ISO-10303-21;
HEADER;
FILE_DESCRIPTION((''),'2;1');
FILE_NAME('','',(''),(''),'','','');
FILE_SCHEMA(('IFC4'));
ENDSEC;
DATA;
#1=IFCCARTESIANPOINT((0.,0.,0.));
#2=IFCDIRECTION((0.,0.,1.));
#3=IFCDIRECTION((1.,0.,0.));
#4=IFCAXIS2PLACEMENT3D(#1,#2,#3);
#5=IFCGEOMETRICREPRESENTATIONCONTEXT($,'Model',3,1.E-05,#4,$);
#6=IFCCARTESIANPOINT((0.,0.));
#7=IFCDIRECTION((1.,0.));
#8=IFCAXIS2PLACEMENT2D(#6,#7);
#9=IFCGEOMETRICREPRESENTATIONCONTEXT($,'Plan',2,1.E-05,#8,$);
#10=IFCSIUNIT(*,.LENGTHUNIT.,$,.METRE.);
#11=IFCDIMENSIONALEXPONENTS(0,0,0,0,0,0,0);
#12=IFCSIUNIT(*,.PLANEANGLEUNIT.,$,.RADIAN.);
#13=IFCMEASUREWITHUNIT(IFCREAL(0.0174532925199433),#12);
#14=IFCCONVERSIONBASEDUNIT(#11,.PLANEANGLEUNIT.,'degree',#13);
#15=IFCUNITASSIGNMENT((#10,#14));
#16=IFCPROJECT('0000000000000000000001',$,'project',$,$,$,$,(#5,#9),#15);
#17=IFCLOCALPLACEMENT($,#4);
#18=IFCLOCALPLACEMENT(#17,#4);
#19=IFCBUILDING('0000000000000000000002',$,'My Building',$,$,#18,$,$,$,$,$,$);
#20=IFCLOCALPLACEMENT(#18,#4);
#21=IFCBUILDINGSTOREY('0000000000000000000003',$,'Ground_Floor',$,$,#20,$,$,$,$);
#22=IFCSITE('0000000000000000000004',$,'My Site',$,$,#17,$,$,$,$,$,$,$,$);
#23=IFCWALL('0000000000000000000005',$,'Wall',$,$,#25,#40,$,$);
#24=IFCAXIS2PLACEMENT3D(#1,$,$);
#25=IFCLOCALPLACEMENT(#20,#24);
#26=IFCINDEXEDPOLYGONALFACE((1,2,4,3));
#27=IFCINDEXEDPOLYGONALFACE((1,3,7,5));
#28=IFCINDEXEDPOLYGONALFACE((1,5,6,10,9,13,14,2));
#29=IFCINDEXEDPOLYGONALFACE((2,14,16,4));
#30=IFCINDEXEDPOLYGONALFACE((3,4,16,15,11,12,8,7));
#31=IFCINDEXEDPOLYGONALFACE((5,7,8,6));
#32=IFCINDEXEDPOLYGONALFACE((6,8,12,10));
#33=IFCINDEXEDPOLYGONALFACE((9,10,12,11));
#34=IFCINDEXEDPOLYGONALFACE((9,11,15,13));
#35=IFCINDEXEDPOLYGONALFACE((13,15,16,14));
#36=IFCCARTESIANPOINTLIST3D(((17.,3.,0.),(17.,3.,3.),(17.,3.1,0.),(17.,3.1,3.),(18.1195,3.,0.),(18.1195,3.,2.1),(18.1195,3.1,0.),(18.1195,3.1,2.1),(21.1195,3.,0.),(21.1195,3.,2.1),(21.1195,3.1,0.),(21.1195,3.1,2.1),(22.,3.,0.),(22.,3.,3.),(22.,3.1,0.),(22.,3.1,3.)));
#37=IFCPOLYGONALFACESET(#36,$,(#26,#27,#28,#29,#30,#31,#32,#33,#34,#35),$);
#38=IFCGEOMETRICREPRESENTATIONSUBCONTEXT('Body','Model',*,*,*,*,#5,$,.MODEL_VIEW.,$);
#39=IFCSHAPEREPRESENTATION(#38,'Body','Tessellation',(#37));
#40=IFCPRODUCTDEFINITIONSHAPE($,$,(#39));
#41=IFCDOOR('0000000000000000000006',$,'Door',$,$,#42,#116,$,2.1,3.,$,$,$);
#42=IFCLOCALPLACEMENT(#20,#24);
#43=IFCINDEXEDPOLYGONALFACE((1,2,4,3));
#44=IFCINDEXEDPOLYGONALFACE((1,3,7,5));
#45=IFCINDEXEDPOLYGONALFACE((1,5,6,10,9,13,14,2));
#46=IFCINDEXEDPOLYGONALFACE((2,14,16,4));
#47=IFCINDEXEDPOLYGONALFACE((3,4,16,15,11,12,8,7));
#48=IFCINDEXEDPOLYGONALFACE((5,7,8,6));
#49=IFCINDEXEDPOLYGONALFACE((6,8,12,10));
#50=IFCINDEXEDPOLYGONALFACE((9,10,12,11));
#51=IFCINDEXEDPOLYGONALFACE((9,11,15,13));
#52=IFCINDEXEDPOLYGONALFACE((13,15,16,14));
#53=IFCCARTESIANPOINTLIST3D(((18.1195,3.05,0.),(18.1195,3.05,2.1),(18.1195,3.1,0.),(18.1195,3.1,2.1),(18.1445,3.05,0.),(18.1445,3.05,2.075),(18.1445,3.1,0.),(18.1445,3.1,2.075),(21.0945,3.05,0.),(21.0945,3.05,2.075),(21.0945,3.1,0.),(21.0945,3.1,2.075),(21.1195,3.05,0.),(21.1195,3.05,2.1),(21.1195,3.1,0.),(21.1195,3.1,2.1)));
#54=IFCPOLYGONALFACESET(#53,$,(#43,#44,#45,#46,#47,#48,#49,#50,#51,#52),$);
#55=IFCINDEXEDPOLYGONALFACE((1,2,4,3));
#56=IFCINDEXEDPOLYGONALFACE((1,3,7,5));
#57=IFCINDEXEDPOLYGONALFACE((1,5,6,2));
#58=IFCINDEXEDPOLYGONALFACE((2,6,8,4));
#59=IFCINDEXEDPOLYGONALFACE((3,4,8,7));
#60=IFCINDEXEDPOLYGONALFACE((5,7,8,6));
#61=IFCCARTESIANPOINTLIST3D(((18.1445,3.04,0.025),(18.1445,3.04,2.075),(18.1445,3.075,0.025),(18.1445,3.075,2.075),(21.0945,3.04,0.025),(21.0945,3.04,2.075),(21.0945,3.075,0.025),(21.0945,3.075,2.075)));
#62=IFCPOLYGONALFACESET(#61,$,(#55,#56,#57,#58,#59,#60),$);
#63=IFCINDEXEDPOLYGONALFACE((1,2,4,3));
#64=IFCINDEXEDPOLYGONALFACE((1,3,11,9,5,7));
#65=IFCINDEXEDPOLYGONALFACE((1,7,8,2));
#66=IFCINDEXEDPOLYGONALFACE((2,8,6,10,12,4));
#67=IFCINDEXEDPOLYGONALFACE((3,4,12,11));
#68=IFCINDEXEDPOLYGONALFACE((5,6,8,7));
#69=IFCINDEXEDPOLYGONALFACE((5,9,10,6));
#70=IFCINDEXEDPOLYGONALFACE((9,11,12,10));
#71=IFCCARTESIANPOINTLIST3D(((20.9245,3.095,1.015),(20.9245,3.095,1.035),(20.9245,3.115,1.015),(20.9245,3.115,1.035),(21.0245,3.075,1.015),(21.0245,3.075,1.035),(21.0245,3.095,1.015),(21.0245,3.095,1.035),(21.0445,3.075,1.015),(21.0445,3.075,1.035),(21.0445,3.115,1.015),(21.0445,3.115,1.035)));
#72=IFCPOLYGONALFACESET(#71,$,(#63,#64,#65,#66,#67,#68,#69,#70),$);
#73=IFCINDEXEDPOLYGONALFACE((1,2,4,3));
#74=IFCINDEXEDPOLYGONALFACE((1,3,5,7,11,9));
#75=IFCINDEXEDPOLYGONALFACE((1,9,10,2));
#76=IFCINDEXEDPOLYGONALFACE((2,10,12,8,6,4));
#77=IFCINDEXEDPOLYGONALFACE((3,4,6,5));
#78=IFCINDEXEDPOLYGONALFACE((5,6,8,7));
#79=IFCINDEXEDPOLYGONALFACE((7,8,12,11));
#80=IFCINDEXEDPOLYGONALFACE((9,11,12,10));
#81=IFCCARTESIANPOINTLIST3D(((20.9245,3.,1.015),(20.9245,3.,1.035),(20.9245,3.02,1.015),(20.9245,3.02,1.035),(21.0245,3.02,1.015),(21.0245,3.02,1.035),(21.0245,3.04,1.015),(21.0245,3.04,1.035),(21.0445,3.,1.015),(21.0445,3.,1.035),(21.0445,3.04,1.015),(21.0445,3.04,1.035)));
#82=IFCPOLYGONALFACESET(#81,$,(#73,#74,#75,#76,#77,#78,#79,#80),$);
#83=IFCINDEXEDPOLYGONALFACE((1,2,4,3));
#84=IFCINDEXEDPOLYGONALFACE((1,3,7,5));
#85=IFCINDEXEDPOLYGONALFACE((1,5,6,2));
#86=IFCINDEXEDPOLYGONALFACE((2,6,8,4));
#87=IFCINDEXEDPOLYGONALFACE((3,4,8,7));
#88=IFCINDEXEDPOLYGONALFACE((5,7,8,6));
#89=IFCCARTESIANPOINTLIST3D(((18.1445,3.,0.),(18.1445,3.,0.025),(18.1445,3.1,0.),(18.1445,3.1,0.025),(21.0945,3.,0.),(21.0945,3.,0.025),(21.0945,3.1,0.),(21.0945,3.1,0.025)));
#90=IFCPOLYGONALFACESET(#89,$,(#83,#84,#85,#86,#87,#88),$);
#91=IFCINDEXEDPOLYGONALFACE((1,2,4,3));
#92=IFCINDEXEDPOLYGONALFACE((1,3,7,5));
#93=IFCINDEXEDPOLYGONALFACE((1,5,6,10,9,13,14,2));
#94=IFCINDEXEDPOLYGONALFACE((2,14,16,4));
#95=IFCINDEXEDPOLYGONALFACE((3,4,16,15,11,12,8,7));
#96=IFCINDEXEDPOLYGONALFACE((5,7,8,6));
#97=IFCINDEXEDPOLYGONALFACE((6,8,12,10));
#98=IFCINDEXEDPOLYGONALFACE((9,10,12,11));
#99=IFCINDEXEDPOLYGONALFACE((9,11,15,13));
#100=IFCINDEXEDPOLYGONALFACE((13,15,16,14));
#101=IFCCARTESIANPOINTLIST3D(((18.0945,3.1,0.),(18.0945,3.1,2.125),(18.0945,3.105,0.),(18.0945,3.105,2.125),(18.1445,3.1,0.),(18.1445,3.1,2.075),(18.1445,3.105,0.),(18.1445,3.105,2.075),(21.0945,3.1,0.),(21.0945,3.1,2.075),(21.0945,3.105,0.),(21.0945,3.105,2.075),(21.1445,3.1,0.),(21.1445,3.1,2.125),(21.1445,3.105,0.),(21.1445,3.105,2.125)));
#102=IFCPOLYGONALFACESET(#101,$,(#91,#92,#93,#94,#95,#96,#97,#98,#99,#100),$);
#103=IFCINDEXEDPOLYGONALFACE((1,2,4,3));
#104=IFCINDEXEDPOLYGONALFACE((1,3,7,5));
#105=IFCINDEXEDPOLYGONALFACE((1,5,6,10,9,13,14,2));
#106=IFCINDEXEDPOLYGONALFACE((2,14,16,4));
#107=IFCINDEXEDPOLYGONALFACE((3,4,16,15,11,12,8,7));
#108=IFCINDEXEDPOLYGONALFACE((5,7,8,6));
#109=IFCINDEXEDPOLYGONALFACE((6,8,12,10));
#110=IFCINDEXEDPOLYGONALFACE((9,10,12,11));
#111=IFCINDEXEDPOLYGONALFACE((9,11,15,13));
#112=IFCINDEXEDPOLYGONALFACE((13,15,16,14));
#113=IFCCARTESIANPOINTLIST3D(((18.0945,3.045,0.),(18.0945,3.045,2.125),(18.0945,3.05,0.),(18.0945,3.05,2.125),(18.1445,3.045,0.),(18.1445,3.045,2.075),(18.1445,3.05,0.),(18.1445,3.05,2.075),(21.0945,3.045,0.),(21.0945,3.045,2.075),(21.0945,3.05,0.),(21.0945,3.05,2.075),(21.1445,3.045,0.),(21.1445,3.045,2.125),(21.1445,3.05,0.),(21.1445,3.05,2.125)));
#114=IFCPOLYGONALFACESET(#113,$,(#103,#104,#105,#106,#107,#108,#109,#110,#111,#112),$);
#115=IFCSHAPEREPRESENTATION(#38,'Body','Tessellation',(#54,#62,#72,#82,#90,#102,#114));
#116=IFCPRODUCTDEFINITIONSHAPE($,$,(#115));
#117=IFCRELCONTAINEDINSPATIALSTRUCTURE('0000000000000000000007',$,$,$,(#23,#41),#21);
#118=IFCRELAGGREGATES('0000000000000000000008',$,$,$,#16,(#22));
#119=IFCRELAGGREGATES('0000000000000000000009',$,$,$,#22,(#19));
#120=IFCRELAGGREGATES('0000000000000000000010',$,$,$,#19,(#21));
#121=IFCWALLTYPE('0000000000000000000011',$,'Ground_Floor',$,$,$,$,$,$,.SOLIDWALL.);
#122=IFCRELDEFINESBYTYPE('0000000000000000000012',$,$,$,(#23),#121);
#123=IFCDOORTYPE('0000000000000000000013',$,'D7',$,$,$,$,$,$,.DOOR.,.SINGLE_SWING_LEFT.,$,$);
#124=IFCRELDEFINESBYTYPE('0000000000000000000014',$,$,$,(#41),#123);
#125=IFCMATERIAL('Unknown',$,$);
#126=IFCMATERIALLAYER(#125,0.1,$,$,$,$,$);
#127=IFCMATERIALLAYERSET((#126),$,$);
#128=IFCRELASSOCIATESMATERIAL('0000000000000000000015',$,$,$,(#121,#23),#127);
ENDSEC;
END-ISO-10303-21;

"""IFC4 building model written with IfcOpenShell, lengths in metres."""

from ifc_helpers import new_model, entity, si_unit, converted_unit, frame, origin_with_axes, origin_2d_with_axis, place, context, subcontext, project, spatial, line, indexed_curve, outline, extrude, shape, source, transform, mapped, material, layer, layer_set, layer_usage, type_object, type_shapes, element, fill, save


model = new_model("IFC4")

# Units and contexts
model_context = context("Model", 3, precision=1e-05, world=origin_with_axes())
plan_context = context("Plan", 2, precision=1e-05, world=origin_2d_with_axis())
body_context_1 = subcontext(model_context, "Body", "Model", "MODEL_VIEW")
body_context_2 = subcontext(plan_context, "Body", "Plan", "PLAN_VIEW")
ifc_project = project(units=[si_unit("LENGTHUNIT", "METRE"), converted_unit("PLANEANGLEUNIT", "degree", entity("IfcReal", 0.0174532925199433), si_unit("PLANEANGLEUNIT", "RADIAN"), dimensions=[0, 0, 0, 0, 0, 0, 0])], contexts=[model_context, plan_context])

# Site, building, storey
site_placement = place(None, origin_with_axes())
site = spatial("IfcSite", under=ifc_project, at=site_placement, Name="My Site")
building_placement = place(site_placement, origin_with_axes())
building = spatial("IfcBuilding", under=site, at=building_placement, Name="My Building")
storey_placement = place(building_placement, origin_with_axes())
storey = spatial("IfcBuildingStorey", under=building, at=storey_placement, Name="Ground_Floor")

# Shared definitions
ifc_material = material(Name="Unknown")

# Shared definitions
ifc_layer = layer(ifc_material, 0.1)
ifc_layer_set = layer_set([ifc_layer])
wall_type = type_object("IfcWallType", Name="Ground_Floor", PredefinedType="SOLIDWALL", material=ifc_layer_set)

# Wall, opening, door
shared_shape_1 = source(origin_with_axes(), body_context_1, "Body", "SweptSolid", [
    extrude(outline(indexed_curve([(0.0, 0.0), (3.0, 0.0), (3.0, 2.1), (0.0, 2.1)], segments=[line(1, 2, 3, 4, 1)])), frame((0.0, -0.6, 0.0), z_axis=(0.0, -1.0, 0.0), x_axis=(1.0, 0.0, 0.0)), (0.0, 0.0, -1.0), 1.2),
])
door_type_1 = type_object("IfcDoorType", Name="D7", OperationType="SINGLE_SWING_LEFT", PredefinedType="DOOR")
shared_shape_2 = source(origin_with_axes(), body_context_1, "Body", "SweptSolid", [
    extrude(outline(indexed_curve([(0.0, 0.0), (0.0, 2.1), (3.0, 2.1), (3.0, 0.0), (2.975, 0.0), (2.975, 2.075), (0.025, 2.075), (0.025, 0.0)], segments=[line(1, 2, 3, 4, 5, 6, 7, 8, 1)])), frame((0.0, 0.0, 0.0), z_axis=(0.0, -1.0, 0.0), x_axis=(1.0, 0.0, 0.0)), (0.0, 0.0, -1.0), 0.05),
    extrude(outline(indexed_curve([(0.0, 0.0), (2.95, 0.0), (2.95, 0.035), (0.0, 0.035)], segments=[line(1, 2, 3, 4, 1)])), frame((0.025, 0.025, 0.025), z_axis=(0.0, 0.0, 1.0), x_axis=(1.0, 0.0, 0.0)), (0.0, 0.0, 1.0), 2.05),
    extrude(outline(indexed_curve([(0.0, 0.0), (0.0, -0.04), (0.12, -0.04), (0.12, -0.02), (0.02, -0.02), (0.02, 0.0)], segments=[line(1, 2, 3, 4, 5, 6, 1)])), frame((0.075, 0.025, 1.015), z_axis=(0.0, 0.0, 1.0), x_axis=(1.0, 0.0, 0.0)), (0.0, 0.0, 1.0), 0.02),
    extrude(outline(indexed_curve([(0.0, 0.0), (0.0, 0.04), (0.12, 0.04), (0.12, 0.02), (0.02, 0.02), (0.02, 0.0)], segments=[line(1, 2, 3, 4, 5, 6, 1)])), frame((0.075, 0.06, 1.015), z_axis=(0.0, 0.0, 1.0), x_axis=(1.0, 0.0, 0.0)), (0.0, 0.0, 1.0), 0.02),
    extrude(outline(indexed_curve([(0.0, 0.0), (2.95, 0.0), (2.95, 0.1), (0.0, 0.1)], segments=[line(1, 2, 3, 4, 1)])), frame((0.025, 0.0, 0.0), z_axis=(0.0, 0.0, 1.0), x_axis=(1.0, 0.0, 0.0)), (0.0, 0.0, 1.0), 0.025),
    extrude(outline(indexed_curve([(0.0, 0.0), (0.0, 2.125), (3.05, 2.125), (3.05, 0.0), (3.0, 0.0), (3.0, 2.075), (0.05, 2.075), (0.05, 0.0)], segments=[line(1, 2, 3, 4, 5, 6, 7, 8, 1)])), frame((-0.025, -0.005, 0.0), z_axis=(0.0, -1.0, 0.0), x_axis=(1.0, 0.0, 0.0)), (0.0, 0.0, -1.0), 0.005),
    extrude(outline(indexed_curve([(0.0, 0.0), (0.0, 2.125), (3.05, 2.125), (3.05, 0.0), (3.0, 0.0), (3.0, 2.075), (0.05, 2.075), (0.05, 0.0)], segments=[line(1, 2, 3, 4, 5, 6, 7, 8, 1)])), frame((-0.025, 0.05, 0.0), z_axis=(0.0, -1.0, 0.0), x_axis=(1.0, 0.0, 0.0)), (0.0, 0.0, -1.0), 0.005),
])
shared_shape_3 = source(origin_with_axes(), body_context_2, "Body", "Curve2D", [
    entity("IfcIndexedPolyCurve", entity("IfcCartesianPointList2D", [[0.0, 0.0], [0.025, 0.0], [0.025, 0.05], [0.0, 0.05]]), [entity("IfcLineIndex", [1, 2, 3, 4, 1])]),
    entity("IfcIndexedPolyCurve", entity("IfcCartesianPointList2D", [[3.0, 0.0], [2.975, 0.0], [2.975, 0.05], [3.0, 0.05]]), [entity("IfcLineIndex", [1, 2, 3, 4, 1])]),
    entity("IfcIndexedPolyCurve", entity("IfcCartesianPointList2D", [[2.975, 0.05], [2.975, -2.9], [2.94, -2.9]])),
    entity("IfcTrimmedCurve", entity("IfcEllipse", entity("IfcAxis2Placement2D", entity("IfcCartesianPoint", [2.94, 0.05]), entity("IfcDirection", [1.0, 0.0])), 2.915, 2.95), [entity("IfcCartesianPoint", [2.94, 3.0])], [entity("IfcCartesianPoint", [2.94, -2.9])], True, "CARTESIAN"),
    entity("IfcIndexedPolyCurve", entity("IfcCartesianPointList2D", [[2.975, 0.05], [2.94, 0.05], [2.94, 3.0], [2.975, 3.0]]), [entity("IfcLineIndex", [1, 2, 3, 4, 1])]),
])
type_shapes(door_type_1, [shared_shape_2, shared_shape_3])
ifc_layer_usage_1 = layer_usage(ifc_layer_set, "AXIS2", "POSITIVE", 0.0)
wall_1_placement = place(storey_placement, frame((17.0, 3.0, 0.0), z_axis=(0.0, 0.0, 1.0), x_axis=(1.0, 0.0, 0.0)))
wall_1 = element("IfcWall", 1, at=wall_1_placement, inside=storey, type_object=wall_type, material=ifc_layer_usage_1, Name="Wall", context=body_context_1, shape_type="SweptSolid", body=[
    extrude(outline(indexed_curve([(0.0, 0.0), (0.0, 0.1), (5.0, 0.1), (5.0, 0.0)], segments=[line(1, 2, 3, 4, 1)])), origin_with_axes(), (0.0, 0.0, 1.0), 3.0),
])
opening_1_placement = place(wall_1_placement, frame((4.1195, 0.1, 0.0), z_axis=(0.0, 0.0, 1.0), x_axis=(-1.0, 0.0, 0.0)))
opening_1 = element("IfcOpeningElement", 2, at=opening_1_placement, cuts=wall_1, PredefinedType="OPENING", context=body_context_1, shape_type="MappedRepresentation", body=[
    mapped(shared_shape_1, transform((0.0, 0.0, 0.0), x_axis=(1.0, 0.0, 0.0), y_axis=(0.0, 1.0, 0.0), z_axis=(0.0, 0.0, 1.0), scale=1.0)),
])
door_1_placement = place(opening_1_placement, origin_with_axes())
door_1 = element("IfcDoor", 3, at=door_1_placement, inside=storey, type_object=door_type_1, Name="Door", OverallHeight=2.1, OverallWidth=3.0, shapes=[
    shape(body_context_1, "Body", "MappedRepresentation", [mapped(shared_shape_2, transform((0.0, 0.0, 0.0), x_axis=(1.0, 0.0, 0.0), y_axis=(0.0, 1.0, 0.0), z_axis=(0.0, 0.0, 1.0), scale=1.0))]),
    shape(body_context_2, "Body", "MappedRepresentation", [mapped(shared_shape_3, transform((0.0, 0.0, 0.0), x_axis=(1.0, 0.0, 0.0), y_axis=(0.0, 1.0, 0.0), z_axis=(0.0, 0.0, 1.0), scale=1.0))]),
])
fill(opening_1, door_1)

save(model, "model.ifc")
